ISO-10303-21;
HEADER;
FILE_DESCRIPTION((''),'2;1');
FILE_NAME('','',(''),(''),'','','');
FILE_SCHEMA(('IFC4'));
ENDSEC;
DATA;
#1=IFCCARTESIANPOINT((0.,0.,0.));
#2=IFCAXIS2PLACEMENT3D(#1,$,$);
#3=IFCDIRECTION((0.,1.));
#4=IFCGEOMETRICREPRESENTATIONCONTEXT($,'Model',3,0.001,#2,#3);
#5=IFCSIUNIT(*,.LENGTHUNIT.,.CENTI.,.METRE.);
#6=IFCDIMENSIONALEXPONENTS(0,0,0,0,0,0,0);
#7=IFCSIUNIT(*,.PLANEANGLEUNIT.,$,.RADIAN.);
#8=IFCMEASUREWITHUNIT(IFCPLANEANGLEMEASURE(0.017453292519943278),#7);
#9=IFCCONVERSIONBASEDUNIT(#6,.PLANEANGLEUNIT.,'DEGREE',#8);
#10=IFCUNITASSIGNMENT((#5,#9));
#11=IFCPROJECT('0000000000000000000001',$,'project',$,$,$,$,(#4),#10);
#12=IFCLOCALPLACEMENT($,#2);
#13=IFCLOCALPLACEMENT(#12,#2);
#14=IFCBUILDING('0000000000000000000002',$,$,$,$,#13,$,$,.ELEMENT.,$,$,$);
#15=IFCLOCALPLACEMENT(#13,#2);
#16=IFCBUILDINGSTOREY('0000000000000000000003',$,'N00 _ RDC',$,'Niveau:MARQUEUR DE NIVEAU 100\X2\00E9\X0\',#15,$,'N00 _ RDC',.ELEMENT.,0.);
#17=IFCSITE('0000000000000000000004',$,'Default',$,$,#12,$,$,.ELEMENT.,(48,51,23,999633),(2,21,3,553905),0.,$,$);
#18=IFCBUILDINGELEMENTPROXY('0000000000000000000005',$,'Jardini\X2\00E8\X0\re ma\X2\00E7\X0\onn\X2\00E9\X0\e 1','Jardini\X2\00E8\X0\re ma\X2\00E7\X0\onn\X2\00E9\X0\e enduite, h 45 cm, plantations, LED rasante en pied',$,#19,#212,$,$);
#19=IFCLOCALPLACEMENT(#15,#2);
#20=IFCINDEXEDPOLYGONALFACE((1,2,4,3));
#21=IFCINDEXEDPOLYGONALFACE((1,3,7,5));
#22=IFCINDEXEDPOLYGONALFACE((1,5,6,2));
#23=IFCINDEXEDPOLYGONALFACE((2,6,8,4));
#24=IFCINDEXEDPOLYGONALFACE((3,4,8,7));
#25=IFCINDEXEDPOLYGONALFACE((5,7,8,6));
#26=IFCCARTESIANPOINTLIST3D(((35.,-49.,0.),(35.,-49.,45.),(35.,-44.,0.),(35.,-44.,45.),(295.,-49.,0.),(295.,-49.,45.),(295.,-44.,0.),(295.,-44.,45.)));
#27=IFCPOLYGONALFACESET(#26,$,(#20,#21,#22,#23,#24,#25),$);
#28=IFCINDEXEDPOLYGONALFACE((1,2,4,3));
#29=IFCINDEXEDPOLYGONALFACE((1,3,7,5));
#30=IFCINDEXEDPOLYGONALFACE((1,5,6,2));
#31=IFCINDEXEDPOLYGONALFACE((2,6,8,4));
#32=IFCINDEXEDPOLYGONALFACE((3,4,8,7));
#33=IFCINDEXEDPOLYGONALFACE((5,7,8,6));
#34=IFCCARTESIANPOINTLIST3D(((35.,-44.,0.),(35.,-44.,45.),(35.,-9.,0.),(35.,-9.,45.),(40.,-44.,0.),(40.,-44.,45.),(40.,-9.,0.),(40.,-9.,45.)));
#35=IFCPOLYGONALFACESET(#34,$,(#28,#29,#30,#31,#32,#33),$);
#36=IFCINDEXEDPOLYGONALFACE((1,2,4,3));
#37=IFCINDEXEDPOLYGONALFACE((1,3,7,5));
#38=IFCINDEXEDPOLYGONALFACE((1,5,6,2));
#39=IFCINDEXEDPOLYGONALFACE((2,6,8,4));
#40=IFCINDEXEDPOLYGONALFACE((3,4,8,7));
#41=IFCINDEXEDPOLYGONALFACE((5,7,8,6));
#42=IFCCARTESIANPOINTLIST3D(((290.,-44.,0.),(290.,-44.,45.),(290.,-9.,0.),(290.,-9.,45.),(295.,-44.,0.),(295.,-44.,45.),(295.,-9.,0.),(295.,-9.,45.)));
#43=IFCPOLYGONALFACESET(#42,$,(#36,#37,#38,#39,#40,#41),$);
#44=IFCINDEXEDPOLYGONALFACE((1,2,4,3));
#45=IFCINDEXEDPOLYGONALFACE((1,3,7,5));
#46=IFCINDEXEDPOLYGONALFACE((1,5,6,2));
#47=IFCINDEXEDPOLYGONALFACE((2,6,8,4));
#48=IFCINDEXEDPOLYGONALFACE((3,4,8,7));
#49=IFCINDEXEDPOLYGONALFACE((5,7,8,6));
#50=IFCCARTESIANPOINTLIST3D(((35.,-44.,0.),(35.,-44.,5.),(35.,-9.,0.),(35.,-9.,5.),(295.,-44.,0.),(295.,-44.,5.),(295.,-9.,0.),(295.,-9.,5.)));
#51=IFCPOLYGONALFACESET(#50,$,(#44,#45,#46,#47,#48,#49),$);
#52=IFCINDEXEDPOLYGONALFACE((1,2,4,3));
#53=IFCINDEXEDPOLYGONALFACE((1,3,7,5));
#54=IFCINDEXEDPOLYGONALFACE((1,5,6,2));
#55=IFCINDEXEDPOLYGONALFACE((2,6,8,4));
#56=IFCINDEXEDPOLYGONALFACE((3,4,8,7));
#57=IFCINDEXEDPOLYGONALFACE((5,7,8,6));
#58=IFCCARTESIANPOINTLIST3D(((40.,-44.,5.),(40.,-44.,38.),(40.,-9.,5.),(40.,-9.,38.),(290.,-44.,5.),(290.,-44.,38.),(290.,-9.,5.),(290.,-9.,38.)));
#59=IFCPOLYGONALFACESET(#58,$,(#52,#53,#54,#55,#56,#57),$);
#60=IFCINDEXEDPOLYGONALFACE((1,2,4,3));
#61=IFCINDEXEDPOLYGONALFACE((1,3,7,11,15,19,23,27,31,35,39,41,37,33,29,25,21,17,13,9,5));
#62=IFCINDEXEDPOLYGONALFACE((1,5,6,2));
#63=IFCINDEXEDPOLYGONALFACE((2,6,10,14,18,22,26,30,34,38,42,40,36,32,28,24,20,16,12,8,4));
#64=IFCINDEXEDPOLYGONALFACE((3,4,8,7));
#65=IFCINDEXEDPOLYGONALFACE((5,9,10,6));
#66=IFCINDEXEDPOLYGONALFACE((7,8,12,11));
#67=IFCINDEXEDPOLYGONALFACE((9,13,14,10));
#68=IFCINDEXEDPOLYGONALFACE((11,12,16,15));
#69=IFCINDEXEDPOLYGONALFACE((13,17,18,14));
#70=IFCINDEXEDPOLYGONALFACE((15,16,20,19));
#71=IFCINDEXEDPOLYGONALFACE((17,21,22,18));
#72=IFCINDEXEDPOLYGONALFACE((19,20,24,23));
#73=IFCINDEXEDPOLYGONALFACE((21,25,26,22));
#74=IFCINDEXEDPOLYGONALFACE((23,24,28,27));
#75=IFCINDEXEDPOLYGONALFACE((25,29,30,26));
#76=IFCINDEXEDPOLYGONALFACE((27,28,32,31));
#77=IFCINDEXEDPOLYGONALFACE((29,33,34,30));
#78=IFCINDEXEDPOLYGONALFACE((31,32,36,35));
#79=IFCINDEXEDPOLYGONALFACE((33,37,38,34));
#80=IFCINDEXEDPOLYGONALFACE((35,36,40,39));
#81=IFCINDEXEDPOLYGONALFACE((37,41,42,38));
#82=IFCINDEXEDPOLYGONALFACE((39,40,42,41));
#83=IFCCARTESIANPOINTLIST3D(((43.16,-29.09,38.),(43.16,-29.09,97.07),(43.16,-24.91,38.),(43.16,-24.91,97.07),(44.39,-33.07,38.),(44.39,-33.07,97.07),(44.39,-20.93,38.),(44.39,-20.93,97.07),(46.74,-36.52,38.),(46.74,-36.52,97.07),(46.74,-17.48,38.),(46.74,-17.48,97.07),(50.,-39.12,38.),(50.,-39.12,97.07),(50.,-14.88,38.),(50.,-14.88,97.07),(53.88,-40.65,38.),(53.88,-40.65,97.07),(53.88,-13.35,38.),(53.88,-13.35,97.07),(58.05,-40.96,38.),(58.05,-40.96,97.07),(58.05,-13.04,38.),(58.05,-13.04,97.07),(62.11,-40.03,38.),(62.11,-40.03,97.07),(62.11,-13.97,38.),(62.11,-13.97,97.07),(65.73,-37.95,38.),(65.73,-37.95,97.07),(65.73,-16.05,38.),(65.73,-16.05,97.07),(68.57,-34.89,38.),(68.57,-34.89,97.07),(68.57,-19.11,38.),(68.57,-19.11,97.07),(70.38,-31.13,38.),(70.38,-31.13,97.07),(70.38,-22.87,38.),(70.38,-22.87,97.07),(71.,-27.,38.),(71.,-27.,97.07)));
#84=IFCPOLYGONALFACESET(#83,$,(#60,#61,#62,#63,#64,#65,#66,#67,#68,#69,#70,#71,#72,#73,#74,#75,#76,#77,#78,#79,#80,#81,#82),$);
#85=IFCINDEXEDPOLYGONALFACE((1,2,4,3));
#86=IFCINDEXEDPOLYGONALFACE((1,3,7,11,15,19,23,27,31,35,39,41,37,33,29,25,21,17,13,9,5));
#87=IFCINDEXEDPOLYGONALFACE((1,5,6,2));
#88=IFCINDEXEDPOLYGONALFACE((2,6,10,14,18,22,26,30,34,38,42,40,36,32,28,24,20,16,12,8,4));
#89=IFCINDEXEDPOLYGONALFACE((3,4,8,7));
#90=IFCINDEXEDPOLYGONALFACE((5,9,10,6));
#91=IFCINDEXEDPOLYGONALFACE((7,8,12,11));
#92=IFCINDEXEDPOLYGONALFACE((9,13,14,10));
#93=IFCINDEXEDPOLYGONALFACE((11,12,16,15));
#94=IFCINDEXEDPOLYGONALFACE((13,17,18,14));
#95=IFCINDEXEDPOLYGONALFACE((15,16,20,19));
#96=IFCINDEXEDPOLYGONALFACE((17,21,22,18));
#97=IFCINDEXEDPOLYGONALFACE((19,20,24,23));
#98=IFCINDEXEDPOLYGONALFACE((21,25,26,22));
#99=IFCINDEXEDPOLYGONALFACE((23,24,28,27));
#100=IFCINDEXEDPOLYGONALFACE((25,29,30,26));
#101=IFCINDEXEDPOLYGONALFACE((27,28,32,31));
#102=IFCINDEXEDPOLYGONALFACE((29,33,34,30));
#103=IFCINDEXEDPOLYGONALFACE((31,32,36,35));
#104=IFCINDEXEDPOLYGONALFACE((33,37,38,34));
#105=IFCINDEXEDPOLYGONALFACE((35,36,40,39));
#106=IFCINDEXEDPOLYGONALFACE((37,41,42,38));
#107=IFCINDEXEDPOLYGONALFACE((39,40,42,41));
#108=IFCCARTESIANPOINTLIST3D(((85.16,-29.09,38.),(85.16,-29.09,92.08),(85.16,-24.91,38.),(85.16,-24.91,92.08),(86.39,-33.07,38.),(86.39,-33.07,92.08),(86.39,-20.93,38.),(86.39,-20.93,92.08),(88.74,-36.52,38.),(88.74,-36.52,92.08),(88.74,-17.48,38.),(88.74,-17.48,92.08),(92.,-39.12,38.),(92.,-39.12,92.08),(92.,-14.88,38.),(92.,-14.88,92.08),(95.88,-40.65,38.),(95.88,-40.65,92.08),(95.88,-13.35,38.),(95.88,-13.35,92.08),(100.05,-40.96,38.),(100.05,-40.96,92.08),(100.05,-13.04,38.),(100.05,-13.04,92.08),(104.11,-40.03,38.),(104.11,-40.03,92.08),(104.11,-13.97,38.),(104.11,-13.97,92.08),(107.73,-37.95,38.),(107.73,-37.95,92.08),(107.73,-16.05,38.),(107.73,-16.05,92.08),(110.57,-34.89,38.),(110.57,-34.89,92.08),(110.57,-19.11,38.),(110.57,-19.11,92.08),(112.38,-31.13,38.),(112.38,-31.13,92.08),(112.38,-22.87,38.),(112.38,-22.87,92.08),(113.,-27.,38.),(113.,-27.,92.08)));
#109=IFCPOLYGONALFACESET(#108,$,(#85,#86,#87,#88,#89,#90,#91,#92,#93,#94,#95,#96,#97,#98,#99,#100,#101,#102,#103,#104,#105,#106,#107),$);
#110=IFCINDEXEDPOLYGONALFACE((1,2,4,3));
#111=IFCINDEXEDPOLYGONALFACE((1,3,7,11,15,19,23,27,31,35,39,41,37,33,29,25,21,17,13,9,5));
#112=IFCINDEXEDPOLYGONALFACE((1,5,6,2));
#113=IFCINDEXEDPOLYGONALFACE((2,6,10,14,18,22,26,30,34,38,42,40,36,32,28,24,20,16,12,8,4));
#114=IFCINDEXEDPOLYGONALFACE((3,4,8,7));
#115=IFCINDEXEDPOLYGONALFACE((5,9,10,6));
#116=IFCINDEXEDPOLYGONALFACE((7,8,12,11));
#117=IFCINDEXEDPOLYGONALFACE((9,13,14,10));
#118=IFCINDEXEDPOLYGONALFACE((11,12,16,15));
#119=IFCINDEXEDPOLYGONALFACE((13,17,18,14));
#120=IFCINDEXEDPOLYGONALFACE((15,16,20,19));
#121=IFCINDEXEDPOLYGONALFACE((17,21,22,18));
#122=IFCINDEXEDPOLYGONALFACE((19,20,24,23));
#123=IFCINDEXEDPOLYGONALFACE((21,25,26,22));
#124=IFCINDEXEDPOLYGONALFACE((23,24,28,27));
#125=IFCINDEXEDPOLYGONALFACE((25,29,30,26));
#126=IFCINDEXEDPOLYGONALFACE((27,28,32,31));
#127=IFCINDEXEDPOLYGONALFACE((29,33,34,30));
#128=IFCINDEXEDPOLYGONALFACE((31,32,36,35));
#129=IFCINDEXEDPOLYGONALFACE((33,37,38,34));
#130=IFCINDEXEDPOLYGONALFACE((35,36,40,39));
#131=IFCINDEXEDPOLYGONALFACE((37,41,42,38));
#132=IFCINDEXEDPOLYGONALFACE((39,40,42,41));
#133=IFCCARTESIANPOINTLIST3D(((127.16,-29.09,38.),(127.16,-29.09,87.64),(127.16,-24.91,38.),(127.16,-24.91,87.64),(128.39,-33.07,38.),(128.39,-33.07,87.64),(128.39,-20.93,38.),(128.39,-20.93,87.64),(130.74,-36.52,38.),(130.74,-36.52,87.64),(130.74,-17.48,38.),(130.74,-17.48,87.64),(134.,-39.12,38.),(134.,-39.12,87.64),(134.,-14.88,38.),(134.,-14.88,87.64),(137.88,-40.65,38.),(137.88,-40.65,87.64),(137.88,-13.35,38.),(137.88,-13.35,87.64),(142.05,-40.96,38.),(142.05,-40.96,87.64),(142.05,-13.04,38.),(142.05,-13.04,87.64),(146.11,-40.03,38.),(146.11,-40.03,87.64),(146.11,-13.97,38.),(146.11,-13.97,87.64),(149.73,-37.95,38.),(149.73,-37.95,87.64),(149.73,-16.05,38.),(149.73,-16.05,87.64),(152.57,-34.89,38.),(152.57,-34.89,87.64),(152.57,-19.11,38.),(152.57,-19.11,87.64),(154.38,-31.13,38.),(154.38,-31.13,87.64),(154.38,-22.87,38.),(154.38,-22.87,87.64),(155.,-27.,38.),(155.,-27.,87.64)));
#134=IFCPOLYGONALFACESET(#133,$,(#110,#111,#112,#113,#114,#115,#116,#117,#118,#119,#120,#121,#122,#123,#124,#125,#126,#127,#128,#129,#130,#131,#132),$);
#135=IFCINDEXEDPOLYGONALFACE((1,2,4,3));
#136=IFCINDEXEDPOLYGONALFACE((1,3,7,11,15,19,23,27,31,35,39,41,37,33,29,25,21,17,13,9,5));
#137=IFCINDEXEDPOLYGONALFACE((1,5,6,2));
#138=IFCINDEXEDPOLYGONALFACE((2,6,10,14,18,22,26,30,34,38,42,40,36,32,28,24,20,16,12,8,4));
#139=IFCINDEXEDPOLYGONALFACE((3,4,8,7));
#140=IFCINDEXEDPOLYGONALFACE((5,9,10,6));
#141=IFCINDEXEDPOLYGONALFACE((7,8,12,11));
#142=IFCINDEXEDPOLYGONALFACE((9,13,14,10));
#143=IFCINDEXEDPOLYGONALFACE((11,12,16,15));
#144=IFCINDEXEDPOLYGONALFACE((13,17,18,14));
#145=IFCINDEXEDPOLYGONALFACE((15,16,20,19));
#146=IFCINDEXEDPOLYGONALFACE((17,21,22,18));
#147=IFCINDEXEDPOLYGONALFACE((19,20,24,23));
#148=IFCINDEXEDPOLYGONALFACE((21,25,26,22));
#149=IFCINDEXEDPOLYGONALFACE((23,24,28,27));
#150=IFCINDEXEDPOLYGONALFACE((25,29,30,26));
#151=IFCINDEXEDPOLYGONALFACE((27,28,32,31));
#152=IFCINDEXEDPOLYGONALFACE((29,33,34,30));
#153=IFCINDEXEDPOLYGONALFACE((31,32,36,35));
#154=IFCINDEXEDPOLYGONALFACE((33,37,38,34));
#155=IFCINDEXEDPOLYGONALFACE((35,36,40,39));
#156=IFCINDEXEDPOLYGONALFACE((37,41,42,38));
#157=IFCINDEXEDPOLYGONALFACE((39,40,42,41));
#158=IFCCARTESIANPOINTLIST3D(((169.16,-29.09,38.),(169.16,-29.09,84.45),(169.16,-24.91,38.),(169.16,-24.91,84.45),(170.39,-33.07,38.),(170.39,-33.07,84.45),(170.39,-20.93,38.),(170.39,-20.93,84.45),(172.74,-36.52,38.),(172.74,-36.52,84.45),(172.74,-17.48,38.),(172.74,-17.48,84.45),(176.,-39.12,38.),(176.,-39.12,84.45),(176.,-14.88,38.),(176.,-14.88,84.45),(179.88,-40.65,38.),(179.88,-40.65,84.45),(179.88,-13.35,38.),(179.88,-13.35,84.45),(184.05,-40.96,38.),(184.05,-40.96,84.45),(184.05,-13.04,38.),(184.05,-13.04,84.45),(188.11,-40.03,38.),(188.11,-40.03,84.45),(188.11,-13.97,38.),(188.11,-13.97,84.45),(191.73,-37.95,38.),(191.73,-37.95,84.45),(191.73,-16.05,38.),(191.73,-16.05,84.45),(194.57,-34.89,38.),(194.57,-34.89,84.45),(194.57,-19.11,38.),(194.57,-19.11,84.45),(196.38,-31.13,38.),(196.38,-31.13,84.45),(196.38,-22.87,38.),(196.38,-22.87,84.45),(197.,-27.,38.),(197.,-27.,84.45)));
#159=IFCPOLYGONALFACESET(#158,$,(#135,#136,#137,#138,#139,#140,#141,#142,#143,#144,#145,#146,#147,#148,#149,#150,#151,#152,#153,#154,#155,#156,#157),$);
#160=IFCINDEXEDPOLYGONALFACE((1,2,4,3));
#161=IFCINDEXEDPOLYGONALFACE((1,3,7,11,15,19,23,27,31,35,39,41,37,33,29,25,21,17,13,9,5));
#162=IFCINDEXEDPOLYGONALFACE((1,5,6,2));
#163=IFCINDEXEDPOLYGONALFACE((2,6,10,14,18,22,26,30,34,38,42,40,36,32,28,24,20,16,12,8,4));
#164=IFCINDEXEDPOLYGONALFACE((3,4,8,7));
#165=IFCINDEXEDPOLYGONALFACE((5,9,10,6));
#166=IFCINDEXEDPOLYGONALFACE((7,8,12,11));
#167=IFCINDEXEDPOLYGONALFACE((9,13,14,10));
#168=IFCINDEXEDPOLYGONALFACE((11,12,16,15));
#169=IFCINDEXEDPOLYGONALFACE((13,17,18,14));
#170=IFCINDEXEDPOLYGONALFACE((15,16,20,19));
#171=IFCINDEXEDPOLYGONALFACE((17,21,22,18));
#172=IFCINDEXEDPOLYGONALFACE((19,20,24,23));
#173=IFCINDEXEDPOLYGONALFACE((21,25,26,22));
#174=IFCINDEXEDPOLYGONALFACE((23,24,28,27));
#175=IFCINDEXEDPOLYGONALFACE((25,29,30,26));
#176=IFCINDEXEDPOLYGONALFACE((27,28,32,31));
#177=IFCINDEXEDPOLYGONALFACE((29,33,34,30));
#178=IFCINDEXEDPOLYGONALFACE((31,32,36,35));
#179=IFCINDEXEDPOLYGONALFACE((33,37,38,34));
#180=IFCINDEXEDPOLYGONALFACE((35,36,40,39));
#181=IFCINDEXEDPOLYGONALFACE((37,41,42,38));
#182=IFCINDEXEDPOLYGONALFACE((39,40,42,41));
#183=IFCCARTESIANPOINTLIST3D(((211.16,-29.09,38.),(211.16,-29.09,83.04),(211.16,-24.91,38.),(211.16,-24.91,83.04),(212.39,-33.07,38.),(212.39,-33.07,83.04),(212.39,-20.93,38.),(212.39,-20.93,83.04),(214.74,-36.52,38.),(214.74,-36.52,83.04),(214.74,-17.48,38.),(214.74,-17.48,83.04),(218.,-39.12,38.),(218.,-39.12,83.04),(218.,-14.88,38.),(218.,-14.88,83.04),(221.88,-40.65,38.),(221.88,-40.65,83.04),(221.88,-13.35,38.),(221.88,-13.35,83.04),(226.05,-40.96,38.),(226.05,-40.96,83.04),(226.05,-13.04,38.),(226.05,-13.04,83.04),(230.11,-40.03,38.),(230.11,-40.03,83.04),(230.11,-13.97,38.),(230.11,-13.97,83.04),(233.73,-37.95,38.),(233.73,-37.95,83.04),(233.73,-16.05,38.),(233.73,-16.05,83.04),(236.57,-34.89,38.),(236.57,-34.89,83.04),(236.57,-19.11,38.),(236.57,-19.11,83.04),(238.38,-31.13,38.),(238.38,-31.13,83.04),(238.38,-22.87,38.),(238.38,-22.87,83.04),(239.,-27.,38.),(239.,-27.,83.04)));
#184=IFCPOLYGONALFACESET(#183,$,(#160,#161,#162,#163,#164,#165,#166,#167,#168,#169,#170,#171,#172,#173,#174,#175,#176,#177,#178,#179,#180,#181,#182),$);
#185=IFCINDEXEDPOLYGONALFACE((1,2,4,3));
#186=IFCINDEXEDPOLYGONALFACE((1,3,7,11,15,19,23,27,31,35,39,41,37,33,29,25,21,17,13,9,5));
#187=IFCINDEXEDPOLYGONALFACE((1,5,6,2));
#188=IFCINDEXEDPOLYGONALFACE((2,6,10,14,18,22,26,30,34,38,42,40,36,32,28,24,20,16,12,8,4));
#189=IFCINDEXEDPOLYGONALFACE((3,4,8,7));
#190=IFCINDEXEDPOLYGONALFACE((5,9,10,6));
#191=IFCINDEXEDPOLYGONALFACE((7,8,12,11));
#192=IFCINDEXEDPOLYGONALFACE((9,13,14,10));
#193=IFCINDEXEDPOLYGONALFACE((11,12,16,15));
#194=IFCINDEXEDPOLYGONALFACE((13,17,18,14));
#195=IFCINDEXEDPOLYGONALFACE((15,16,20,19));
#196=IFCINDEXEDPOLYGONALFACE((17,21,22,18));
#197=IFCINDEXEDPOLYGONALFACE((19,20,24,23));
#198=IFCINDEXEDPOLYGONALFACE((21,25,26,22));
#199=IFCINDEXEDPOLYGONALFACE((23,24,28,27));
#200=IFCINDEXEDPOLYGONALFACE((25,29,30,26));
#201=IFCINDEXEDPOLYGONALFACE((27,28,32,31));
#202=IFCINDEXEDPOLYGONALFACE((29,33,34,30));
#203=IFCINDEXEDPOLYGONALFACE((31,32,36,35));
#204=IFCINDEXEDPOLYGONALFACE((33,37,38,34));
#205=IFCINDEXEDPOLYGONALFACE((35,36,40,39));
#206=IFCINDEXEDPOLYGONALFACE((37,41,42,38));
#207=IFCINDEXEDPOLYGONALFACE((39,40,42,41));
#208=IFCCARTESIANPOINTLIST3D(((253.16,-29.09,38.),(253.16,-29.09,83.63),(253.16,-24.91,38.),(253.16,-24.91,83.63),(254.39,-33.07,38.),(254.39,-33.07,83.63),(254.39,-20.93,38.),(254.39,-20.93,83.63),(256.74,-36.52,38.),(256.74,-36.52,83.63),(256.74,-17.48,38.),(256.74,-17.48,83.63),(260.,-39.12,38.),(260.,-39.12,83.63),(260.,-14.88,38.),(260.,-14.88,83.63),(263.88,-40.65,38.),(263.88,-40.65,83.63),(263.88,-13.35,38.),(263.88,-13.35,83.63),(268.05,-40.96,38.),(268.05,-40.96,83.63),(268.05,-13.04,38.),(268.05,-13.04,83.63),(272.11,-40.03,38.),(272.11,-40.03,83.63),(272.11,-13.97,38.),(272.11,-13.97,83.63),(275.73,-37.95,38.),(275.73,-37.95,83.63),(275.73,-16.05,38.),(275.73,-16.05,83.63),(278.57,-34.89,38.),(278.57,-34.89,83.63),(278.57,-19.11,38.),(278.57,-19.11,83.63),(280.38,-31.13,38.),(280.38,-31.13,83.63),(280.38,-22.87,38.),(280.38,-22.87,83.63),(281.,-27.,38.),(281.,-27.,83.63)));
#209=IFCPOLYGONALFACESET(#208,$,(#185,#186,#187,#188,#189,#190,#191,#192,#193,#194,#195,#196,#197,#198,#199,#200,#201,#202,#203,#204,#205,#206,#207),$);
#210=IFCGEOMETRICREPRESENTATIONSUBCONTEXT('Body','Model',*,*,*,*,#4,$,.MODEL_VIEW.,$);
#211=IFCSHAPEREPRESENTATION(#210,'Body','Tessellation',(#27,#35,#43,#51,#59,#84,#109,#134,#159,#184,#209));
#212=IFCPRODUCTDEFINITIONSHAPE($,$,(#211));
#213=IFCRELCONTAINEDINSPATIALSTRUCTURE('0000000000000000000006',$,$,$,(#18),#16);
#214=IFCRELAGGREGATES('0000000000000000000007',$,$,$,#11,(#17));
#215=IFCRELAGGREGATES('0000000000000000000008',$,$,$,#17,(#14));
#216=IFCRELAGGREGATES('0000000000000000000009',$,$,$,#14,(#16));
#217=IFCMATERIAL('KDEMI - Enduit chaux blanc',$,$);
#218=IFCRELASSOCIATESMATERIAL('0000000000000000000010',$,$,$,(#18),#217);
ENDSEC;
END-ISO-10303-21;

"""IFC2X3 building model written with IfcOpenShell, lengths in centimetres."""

from ifc_helpers import new_model, entity, si_unit, converted_unit, direction, frame, frame_2d, origin, origin_with_axes, place, context, subcontext, project, spatial, rectangle, circle, extrude, material, element, save


model = new_model("IFC2X3")

# Units and contexts
model_context = context("Model", 3, precision=0.001, world=origin(), true_north=direction((0.0, 1.0)))
body_context = subcontext(model_context, "Body", "Model", "MODEL_VIEW")
ifc_project = project(units=[si_unit("LENGTHUNIT", "METRE", prefix="CENTI"), converted_unit("PLANEANGLEUNIT", "DEGREE", entity("IfcPlaneAngleMeasure", 0.017453292519943278), si_unit("PLANEANGLEUNIT", "RADIAN"), dimensions=[0, 0, 0, 0, 0, 0, 0])], contexts=[model_context])

# Site, building, storey
site_placement = place(None, origin())
site = spatial("IfcSite", under=ifc_project, at=site_placement, Name="Default", CompositionType="ELEMENT", RefLatitude=(48, 51, 23, 999633), RefLongitude=(2, 21, 3, 553905), RefElevation=0.0)
building_placement = place(site_placement, origin())
building = spatial("IfcBuilding", under=site, at=building_placement, CompositionType="ELEMENT")
storey_placement = place(building_placement, origin())
storey = spatial("IfcBuildingStorey", under=building, at=storey_placement, Name="N00 _ RDC", ObjectType="Niveau:MARQUEUR DE NIVEAU 100é", LongName="N00 _ RDC", CompositionType="ELEMENT", Elevation=0.0)

# Building element proxy
ifc_material_1 = material(Name="KDEMI - Enduit chaux blanc")
proxy_1_placement = place(storey_placement, origin_with_axes())
element("IfcBuildingElementProxy", 1, at=proxy_1_placement, inside=storey, material=ifc_material_1, Name="Jardinière maçonnée 1", Description="Jardinière maçonnée enduite, h 45 cm, plantations, LED rasante en pied", context=body_context, shape_type="SweptSolid", body=[
    extrude(rectangle(XDim=260.0, YDim=5.0, at=frame_2d((165.0, -46.5))), origin(), (0.0, 0.0, 1.0), 45.0),
    extrude(rectangle(XDim=5.0, YDim=35.0, at=frame_2d((37.5, -26.5))), origin(), (0.0, 0.0, 1.0), 45.0),
    extrude(rectangle(XDim=5.0, YDim=35.0, at=frame_2d((292.5, -26.5))), origin(), (0.0, 0.0, 1.0), 45.0),
    extrude(rectangle(XDim=260.0, YDim=35.0, at=frame_2d((165.0, -26.5))), origin(), (0.0, 0.0, 1.0), 5.0),
    extrude(rectangle(XDim=250.0, YDim=35.0, at=frame_2d((165.0, -26.5))), frame((0.0, 0.0, 5.0)), (0.0, 0.0, 1.0), 33.0),
    extrude(circle(Radius=14.0, at=frame_2d((57.0, -27.0))), frame((0.0, 0.0, 38.0)), (0.0, 0.0, 1.0), 59.07),
    extrude(circle(Radius=14.0, at=frame_2d((99.0, -27.0))), frame((0.0, 0.0, 38.0)), (0.0, 0.0, 1.0), 54.08),
    extrude(circle(Radius=14.0, at=frame_2d((141.0, -27.0))), frame((0.0, 0.0, 38.0)), (0.0, 0.0, 1.0), 49.64),
    extrude(circle(Radius=14.0, at=frame_2d((183.0, -27.0))), frame((0.0, 0.0, 38.0)), (0.0, 0.0, 1.0), 46.45),
    extrude(circle(Radius=14.0, at=frame_2d((225.0, -27.0))), frame((0.0, 0.0, 38.0)), (0.0, 0.0, 1.0), 45.04),
    extrude(circle(Radius=14.0, at=frame_2d((267.0, -27.0))), frame((0.0, 0.0, 38.0)), (0.0, 0.0, 1.0), 45.63),
])

save(model, "model.ifc")
